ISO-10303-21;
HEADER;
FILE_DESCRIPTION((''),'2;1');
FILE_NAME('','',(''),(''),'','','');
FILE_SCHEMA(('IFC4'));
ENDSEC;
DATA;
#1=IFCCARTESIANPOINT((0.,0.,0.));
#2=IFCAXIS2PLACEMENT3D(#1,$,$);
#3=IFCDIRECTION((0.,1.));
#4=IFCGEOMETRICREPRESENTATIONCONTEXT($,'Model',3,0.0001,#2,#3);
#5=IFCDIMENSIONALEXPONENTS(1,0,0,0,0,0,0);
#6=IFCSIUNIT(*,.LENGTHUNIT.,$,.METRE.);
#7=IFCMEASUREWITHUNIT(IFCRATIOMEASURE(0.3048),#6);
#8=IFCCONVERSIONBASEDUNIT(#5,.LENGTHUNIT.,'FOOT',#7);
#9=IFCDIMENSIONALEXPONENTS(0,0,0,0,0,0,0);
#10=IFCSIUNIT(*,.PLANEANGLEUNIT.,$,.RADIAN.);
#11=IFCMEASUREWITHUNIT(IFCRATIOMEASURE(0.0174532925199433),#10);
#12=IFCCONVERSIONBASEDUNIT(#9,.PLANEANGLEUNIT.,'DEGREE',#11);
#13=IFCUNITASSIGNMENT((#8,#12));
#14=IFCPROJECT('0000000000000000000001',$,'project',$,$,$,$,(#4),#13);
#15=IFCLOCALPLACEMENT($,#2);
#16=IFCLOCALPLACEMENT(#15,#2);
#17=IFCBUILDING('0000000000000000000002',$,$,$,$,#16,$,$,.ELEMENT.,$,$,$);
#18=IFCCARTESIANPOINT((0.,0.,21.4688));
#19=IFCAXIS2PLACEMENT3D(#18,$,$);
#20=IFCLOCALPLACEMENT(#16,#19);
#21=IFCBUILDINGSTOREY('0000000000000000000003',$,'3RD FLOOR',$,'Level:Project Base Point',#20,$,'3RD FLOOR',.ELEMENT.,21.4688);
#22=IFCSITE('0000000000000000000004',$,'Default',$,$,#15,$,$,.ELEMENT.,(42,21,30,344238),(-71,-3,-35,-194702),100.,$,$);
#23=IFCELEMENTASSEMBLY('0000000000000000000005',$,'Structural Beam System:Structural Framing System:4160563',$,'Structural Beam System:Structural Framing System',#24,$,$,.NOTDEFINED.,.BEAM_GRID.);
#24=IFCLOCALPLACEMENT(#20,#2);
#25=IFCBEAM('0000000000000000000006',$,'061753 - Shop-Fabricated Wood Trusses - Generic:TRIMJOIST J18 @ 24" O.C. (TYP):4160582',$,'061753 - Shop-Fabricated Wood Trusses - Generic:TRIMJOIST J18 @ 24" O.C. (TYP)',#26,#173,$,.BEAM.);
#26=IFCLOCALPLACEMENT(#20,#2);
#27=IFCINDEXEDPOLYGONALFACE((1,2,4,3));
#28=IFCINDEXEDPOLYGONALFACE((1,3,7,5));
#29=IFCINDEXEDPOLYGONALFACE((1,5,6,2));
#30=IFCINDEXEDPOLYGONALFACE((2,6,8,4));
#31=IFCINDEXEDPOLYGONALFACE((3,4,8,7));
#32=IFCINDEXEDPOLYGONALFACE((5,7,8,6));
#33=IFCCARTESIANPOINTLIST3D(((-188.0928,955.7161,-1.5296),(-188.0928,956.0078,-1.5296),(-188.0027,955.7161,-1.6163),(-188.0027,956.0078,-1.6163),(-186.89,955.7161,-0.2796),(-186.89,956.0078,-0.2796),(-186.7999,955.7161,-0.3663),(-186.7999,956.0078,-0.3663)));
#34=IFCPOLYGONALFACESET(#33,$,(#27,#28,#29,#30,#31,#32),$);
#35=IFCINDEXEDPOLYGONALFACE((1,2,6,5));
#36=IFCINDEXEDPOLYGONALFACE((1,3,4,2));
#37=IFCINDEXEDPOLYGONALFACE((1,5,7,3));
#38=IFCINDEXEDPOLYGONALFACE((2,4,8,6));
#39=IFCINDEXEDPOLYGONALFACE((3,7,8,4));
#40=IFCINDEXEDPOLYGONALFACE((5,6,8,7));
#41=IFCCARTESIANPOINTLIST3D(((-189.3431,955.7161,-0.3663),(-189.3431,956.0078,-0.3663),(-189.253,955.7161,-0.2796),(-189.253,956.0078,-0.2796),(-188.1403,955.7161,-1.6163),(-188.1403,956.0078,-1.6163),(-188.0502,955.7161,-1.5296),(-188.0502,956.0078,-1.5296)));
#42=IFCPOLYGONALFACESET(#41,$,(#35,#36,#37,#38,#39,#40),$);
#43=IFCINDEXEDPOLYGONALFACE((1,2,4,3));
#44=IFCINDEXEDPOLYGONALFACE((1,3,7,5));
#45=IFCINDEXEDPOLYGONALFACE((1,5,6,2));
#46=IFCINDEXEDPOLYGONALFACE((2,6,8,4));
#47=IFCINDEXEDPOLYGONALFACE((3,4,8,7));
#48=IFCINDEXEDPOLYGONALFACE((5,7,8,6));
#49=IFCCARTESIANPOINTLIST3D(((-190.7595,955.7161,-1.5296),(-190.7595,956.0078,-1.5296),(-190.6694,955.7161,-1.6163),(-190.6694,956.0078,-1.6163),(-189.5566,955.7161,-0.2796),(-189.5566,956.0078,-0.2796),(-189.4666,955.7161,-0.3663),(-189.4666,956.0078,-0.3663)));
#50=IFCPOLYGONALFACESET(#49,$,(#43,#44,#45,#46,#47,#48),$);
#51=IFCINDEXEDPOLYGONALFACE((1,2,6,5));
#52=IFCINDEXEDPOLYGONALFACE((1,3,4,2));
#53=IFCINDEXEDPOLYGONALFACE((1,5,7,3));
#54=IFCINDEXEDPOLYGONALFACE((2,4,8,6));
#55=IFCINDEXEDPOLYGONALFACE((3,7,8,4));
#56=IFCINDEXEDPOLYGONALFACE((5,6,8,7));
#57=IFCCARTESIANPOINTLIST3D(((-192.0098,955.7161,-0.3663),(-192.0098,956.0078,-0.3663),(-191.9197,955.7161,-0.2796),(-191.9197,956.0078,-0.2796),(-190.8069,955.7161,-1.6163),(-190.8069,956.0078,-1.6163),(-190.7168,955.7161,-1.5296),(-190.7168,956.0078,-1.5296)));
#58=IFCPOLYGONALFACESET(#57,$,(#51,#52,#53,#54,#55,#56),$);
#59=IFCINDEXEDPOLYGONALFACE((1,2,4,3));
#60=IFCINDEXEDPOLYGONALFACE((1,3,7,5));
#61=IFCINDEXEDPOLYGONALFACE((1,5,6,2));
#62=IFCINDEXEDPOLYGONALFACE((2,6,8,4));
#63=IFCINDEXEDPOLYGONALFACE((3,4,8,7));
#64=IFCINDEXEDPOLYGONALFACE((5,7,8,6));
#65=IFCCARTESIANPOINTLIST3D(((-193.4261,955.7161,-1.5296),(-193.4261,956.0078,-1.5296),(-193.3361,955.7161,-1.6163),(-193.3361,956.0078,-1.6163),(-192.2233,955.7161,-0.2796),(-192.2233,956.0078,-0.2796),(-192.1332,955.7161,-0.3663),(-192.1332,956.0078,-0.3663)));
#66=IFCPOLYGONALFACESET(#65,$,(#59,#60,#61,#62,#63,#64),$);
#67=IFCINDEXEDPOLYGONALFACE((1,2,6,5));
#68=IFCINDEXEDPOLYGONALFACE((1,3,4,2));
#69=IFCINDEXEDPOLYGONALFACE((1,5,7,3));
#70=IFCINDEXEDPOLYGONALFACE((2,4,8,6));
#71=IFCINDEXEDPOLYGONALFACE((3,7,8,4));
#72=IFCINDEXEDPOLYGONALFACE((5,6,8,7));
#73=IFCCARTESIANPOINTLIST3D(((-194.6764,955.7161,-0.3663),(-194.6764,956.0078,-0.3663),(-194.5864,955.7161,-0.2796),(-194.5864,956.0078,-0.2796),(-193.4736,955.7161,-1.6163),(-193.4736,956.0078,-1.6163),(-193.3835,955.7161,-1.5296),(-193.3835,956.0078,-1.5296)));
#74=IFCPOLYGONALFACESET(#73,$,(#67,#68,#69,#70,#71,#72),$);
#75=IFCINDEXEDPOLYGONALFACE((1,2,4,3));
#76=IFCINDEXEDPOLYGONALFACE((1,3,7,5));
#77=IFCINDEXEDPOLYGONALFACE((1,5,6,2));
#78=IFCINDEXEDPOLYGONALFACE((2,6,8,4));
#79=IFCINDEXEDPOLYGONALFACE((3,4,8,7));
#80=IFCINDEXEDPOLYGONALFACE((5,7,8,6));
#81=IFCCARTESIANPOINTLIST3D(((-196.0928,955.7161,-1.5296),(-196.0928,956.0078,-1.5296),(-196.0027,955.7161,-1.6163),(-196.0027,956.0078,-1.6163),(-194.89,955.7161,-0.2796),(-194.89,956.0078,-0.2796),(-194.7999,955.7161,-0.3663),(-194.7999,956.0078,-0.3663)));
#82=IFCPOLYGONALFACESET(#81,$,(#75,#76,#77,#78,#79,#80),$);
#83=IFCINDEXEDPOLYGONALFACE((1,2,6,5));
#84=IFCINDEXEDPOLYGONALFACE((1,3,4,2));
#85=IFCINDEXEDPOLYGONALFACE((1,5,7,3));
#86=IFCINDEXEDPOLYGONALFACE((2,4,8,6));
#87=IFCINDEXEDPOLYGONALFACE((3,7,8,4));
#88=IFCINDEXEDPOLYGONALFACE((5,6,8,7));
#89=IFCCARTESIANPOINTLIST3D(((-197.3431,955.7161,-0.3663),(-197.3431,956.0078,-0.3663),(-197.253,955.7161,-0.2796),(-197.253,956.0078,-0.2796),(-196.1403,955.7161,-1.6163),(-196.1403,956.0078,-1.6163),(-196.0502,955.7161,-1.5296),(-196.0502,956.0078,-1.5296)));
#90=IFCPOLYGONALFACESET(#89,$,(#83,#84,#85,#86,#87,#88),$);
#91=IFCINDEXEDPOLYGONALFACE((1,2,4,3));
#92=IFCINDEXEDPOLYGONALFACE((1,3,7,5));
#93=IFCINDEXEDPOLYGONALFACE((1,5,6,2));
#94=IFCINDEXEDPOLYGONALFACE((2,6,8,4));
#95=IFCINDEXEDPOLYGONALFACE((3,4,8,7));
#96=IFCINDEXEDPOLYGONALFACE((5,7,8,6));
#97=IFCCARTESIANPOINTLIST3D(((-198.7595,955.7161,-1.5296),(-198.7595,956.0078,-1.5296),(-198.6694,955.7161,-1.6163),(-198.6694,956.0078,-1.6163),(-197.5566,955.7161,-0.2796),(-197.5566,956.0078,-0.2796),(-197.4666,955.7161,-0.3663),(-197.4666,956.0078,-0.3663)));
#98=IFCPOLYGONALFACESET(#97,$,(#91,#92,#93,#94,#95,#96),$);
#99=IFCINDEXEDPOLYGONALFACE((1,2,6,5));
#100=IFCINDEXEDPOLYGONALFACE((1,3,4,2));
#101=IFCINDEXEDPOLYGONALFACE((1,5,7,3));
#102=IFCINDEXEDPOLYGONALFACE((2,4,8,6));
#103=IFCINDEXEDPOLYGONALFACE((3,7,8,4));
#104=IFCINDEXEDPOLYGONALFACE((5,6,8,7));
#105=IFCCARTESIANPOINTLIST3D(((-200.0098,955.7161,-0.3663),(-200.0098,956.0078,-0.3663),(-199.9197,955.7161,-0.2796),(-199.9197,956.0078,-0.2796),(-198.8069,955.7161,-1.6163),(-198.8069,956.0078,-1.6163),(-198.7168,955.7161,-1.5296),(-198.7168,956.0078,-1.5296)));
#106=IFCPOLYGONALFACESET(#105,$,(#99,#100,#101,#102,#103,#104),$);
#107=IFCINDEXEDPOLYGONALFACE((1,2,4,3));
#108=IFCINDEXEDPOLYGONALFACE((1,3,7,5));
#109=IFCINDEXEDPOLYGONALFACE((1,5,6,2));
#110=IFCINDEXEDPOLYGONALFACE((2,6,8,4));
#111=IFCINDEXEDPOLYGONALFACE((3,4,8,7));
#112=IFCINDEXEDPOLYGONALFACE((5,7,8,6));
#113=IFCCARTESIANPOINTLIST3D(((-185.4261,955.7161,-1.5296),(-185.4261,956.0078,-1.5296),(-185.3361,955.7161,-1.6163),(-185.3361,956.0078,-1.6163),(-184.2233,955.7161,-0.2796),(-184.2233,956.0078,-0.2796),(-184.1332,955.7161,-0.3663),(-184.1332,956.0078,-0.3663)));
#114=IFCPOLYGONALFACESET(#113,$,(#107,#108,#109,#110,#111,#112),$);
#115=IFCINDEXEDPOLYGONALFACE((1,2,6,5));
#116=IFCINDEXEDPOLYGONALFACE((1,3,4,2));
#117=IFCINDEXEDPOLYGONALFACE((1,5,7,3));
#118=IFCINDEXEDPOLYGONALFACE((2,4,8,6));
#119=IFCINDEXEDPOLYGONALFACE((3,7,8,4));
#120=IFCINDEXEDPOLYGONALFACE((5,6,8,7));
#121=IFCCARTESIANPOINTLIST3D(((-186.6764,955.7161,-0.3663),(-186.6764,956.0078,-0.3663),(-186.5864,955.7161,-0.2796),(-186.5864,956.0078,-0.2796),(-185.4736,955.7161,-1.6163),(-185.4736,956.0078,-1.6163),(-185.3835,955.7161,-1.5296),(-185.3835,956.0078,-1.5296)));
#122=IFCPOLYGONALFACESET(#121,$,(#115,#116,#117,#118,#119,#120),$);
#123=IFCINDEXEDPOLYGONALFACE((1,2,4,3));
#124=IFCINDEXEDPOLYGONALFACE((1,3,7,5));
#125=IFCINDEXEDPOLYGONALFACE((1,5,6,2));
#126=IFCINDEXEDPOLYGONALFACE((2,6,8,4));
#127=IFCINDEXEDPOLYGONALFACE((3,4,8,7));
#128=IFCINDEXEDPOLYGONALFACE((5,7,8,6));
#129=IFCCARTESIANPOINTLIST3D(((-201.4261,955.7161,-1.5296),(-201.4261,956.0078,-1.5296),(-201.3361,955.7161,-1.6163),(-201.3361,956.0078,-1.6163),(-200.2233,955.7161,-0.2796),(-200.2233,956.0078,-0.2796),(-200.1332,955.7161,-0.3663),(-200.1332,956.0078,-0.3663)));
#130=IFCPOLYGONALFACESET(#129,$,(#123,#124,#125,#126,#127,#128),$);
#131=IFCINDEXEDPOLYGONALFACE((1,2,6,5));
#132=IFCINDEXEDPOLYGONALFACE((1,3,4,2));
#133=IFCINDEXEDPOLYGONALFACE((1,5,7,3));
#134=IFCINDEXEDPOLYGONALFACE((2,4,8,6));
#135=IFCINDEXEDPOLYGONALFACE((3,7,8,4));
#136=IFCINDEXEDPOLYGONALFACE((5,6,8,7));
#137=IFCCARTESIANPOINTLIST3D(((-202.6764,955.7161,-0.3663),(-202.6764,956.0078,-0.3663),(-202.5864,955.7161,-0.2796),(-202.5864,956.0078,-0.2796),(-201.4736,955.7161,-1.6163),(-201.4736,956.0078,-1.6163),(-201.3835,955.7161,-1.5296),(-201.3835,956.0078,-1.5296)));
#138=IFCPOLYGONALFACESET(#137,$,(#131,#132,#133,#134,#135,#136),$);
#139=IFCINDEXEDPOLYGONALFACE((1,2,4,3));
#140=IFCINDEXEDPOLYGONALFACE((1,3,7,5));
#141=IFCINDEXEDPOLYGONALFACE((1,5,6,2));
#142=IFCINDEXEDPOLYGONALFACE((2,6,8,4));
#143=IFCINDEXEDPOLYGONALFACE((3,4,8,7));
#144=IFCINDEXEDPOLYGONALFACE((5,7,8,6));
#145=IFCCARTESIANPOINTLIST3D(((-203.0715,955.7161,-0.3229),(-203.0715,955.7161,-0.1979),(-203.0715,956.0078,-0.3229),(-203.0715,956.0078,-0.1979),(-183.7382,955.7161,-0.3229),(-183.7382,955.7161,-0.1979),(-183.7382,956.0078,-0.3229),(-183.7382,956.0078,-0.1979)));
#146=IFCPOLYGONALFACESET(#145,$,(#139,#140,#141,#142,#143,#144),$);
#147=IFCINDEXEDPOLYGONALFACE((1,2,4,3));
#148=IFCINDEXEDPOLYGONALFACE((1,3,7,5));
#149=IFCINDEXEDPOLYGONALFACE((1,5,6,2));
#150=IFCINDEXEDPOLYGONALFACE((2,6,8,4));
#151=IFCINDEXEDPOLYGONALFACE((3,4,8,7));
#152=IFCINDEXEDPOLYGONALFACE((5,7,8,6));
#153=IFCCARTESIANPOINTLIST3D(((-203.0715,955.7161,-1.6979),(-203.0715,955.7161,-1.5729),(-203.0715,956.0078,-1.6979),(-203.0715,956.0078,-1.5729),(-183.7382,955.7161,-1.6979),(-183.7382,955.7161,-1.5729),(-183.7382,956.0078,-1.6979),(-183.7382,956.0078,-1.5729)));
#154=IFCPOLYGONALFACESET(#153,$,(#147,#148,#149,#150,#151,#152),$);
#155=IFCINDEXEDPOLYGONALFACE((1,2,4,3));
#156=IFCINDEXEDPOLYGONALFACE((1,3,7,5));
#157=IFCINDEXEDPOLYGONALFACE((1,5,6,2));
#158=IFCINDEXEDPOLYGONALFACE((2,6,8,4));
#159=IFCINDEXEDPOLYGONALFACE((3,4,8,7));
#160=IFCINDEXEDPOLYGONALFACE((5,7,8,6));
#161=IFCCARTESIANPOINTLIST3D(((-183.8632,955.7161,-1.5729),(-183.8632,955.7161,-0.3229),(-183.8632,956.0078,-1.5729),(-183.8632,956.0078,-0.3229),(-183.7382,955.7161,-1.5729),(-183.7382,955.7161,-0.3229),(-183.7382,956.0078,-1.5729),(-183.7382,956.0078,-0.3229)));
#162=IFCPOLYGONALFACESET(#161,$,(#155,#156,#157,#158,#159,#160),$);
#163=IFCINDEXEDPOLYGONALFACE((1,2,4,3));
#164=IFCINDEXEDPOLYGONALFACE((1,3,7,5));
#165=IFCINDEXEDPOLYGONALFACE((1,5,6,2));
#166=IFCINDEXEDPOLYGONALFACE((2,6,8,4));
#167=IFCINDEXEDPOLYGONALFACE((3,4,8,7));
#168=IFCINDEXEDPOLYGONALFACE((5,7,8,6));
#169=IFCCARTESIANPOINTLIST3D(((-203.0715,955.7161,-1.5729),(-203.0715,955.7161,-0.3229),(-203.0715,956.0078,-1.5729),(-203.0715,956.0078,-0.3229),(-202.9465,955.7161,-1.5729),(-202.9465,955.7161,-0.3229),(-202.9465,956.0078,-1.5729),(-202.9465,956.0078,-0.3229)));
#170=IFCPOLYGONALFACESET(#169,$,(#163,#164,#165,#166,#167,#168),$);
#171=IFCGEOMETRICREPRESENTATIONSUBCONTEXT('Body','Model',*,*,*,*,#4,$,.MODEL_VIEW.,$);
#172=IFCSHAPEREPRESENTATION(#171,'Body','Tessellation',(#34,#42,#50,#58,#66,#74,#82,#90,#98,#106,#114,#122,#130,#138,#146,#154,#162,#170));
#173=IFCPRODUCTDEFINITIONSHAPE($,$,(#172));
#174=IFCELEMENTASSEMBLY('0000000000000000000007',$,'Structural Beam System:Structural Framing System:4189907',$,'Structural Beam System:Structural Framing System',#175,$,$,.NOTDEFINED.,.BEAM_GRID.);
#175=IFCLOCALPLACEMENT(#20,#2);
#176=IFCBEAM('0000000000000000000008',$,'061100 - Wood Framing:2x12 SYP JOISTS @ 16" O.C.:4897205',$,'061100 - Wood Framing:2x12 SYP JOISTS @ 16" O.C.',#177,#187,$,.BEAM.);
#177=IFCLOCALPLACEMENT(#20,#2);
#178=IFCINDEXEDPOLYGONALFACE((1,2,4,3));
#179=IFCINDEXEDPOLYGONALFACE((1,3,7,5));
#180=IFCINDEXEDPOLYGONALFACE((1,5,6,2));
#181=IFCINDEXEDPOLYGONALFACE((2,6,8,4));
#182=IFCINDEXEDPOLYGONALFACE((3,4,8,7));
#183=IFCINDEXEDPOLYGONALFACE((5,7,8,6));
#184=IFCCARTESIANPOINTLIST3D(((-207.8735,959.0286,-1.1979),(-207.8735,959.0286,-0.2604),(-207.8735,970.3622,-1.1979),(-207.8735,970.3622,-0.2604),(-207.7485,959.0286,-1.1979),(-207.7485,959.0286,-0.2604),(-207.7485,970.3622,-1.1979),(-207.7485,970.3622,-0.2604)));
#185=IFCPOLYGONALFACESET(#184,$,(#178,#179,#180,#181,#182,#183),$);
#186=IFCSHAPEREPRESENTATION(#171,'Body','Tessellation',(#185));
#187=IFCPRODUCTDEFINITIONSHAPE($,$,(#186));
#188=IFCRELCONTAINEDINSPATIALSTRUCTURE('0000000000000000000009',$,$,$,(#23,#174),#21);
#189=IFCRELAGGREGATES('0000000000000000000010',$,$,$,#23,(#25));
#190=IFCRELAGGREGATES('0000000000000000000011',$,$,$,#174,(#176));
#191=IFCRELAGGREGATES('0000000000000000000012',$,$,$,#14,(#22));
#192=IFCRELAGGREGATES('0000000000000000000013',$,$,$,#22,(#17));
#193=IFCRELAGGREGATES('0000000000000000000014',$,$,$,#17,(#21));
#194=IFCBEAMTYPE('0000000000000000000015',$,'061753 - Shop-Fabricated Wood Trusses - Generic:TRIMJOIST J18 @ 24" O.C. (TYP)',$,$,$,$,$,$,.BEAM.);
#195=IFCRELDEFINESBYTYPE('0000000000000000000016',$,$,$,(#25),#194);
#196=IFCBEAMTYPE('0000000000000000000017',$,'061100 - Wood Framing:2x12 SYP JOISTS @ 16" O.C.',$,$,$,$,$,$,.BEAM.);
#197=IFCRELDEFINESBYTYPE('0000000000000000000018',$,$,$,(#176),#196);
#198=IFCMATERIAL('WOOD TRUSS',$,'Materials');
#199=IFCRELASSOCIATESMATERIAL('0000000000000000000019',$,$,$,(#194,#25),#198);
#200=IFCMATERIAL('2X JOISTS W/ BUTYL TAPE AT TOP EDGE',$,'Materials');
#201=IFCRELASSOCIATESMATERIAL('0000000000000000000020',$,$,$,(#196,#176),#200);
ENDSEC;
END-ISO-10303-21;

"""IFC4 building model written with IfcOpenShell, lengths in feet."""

from ifc_helpers import new_model, entity, si_unit, converted_unit, direction, frame, frame_2d, origin, origin_2d_with_axis, place, context, subcontext, project, spatial, rectangle, extrude, source, transform, mapped, material, material_profile, profile_set, profile_usage, type_object, type_shapes, element, aggregate, save


model = new_model("IFC4")

# Units and contexts
model_context = context("Model", 3, precision=0.0001, world=origin(), true_north=direction((0.0, 1.0)))
body_context = subcontext(model_context, "Body", "Model", "MODEL_VIEW")
ifc_project = project(units=[converted_unit("LENGTHUNIT", "FOOT", entity("IfcRatioMeasure", 0.3048), si_unit("LENGTHUNIT", "METRE"), dimensions=[1, 0, 0, 0, 0, 0, 0]), converted_unit("PLANEANGLEUNIT", "DEGREE", entity("IfcRatioMeasure", 0.0174532925199433), si_unit("PLANEANGLEUNIT", "RADIAN"), dimensions=[0, 0, 0, 0, 0, 0, 0])], contexts=[model_context])

# Site, building, storey
site_placement = place(None, origin())
site = spatial("IfcSite", under=ifc_project, at=site_placement, Name="Default", CompositionType="ELEMENT", RefLatitude=(42, 21, 30, 344238), RefLongitude=(-71, -3, -35, -194702), RefElevation=100.0)
building_placement = place(site_placement, origin())
building = spatial("IfcBuilding", under=site, at=building_placement, CompositionType="ELEMENT")
storey_placement = place(building_placement, frame((0.0, 0.0, 21.4688)))
storey = spatial("IfcBuildingStorey", under=building, at=storey_placement, Name="3RD FLOOR", ObjectType="Level:Project Base Point", LongName="3RD FLOOR", CompositionType="ELEMENT", Elevation=21.4688)

# Shared definitions
ifc_material_1 = material(Name="WOOD TRUSS", Category="Materials")
ifc_material_profile_1 = material_profile(ifc_material_1, rectangle(XDim=1.7347, YDim=0.125, at=frame_2d((0.0, 0.0), x_axis=(1.0, 0.0))), Name="TRIMJOIST J18 @ 24\" O.C. (TYP)")
ifc_material_profile_2 = material_profile(ifc_material_1, rectangle(XDim=1.7347, YDim=0.125, at=frame_2d((0.0, 0.0), x_axis=(1.0, 0.0))), Name="TRIMJOIST J18 @ 24\" O.C. (TYP)")
ifc_material_profile_3 = material_profile(ifc_material_1, rectangle(XDim=1.7347, YDim=0.125, at=frame_2d((0.0, 0.0), x_axis=(1.0, 0.0))), Name="TRIMJOIST J18 @ 24\" O.C. (TYP)")
ifc_material_profile_4 = material_profile(ifc_material_1, rectangle(XDim=1.7347, YDim=0.125, at=frame_2d((0.0, 0.0), x_axis=(1.0, 0.0))), Name="TRIMJOIST J18 @ 24\" O.C. (TYP)")
ifc_material_profile_5 = material_profile(ifc_material_1, rectangle(XDim=1.7347, YDim=0.125, at=frame_2d((0.0, 0.0), x_axis=(1.0, 0.0))), Name="TRIMJOIST J18 @ 24\" O.C. (TYP)")
ifc_material_profile_6 = material_profile(ifc_material_1, rectangle(XDim=1.7347, YDim=0.125, at=frame_2d((0.0, 0.0), x_axis=(1.0, 0.0))), Name="TRIMJOIST J18 @ 24\" O.C. (TYP)")
ifc_material_profile_7 = material_profile(ifc_material_1, rectangle(XDim=1.7347, YDim=0.125, at=frame_2d((0.0, 0.0), x_axis=(1.0, 0.0))), Name="TRIMJOIST J18 @ 24\" O.C. (TYP)")
ifc_material_profile_8 = material_profile(ifc_material_1, rectangle(XDim=1.7347, YDim=0.125, at=frame_2d((0.0, 0.0), x_axis=(1.0, 0.0))), Name="TRIMJOIST J18 @ 24\" O.C. (TYP)")
ifc_material_profile_9 = material_profile(ifc_material_1, rectangle(XDim=1.7347, YDim=0.125, at=frame_2d((0.0, 0.0), x_axis=(1.0, 0.0))), Name="TRIMJOIST J18 @ 24\" O.C. (TYP)")
ifc_material_profile_10 = material_profile(ifc_material_1, rectangle(XDim=1.7347, YDim=0.125, at=origin_2d_with_axis()), Name="TRIMJOIST J18 @ 24\" O.C. (TYP)")
ifc_material_profile_11 = material_profile(ifc_material_1, rectangle(XDim=0.125, YDim=0.2917, at=origin_2d_with_axis()), Name="TRIMJOIST J18 @ 24\" O.C. (TYP)")
ifc_material_profile_12 = material_profile(ifc_material_1, rectangle(XDim=0.125, YDim=0.2917, at=origin_2d_with_axis()), Name="TRIMJOIST J18 @ 24\" O.C. (TYP)")
ifc_material_profile_13 = material_profile(ifc_material_1, rectangle(XDim=1.25, YDim=0.2917, at=origin_2d_with_axis()), Name="TRIMJOIST J18 @ 24\" O.C. (TYP)")
ifc_material_profile_14 = material_profile(ifc_material_1, rectangle(XDim=1.25, YDim=0.2917, at=origin_2d_with_axis()), Name="TRIMJOIST J18 @ 24\" O.C. (TYP)")
ifc_profile_set_1 = profile_set([ifc_material_profile_1, ifc_material_profile_2, ifc_material_profile_3, ifc_material_profile_4, ifc_material_profile_5, ifc_material_profile_6, ifc_material_profile_7, ifc_material_profile_8, ifc_material_profile_9, ifc_material_profile_10, ifc_material_profile_11, ifc_material_profile_12, ifc_material_profile_13, ifc_material_profile_14], Name="TRIMJOIST J18 @ 24\" O.C. (TYP)")

# Element assembly
assembly_1_placement = place(storey_placement, origin())
assembly_1 = element("IfcElementAssembly", 1, at=assembly_1_placement, inside=storey, Name="Structural Beam System:Structural Framing System:4160563", ObjectType="Structural Beam System:Structural Framing System", AssemblyPlace="NOTDEFINED", PredefinedType="BEAM_GRID")

# Beam
ifc_profile_usage_1 = profile_usage(ifc_profile_set_1, cardinal=8)
beam_type_1 = type_object("IfcBeamType", Name="061753 - Shop-Fabricated Wood Trusses - Generic:TRIMJOIST J18 @ 24\" O.C. (TYP)", PredefinedType="BEAM", material=ifc_profile_set_1)
shared_shape_1 = source(origin(), body_context, "Body", "SweptSolid", [
    extrude(rectangle(XDim=1.7347, YDim=0.125, at=frame_2d((0.0, 0.0), x_axis=(1.0, 0.0))), frame((5.9585, -0.1458, 0.0), z_axis=(0.0, 1.0, 0.0), x_axis=(0.693383, 0.0, 0.720569)), (0.0, 0.0, 1.0), 0.2917),
    extrude(rectangle(XDim=1.7347, YDim=0.125, at=origin_2d_with_axis()), frame((4.7082, -0.1458, 0.0), z_axis=(0.0, 1.0, 0.0), x_axis=(0.693383, 0.0, -0.720569)), (0.0, 0.0, 1.0), 0.2917),
    extrude(rectangle(XDim=1.7347, YDim=0.125, at=frame_2d((0.0, 0.0), x_axis=(1.0, 0.0))), frame((3.2918, -0.1458, 0.0), z_axis=(0.0, 1.0, 0.0), x_axis=(0.693383, 0.0, 0.720569)), (0.0, 0.0, 1.0), 0.2917),
    extrude(rectangle(XDim=1.7347, YDim=0.125, at=frame_2d((0.0, 0.0), x_axis=(1.0, 0.0))), frame((2.0415, -0.1458, 0.0), z_axis=(0.0, 1.0, 0.0), x_axis=(0.693383, 0.0, -0.720569)), (0.0, 0.0, 1.0), 0.2917),
    extrude(rectangle(XDim=1.7347, YDim=0.125, at=frame_2d((0.0, 0.0), x_axis=(1.0, 0.0))), frame((0.6251, -0.1458, 0.0), z_axis=(0.0, 1.0, 0.0), x_axis=(0.693383, 0.0, 0.720569)), (0.0, 0.0, 1.0), 0.2917),
    extrude(rectangle(XDim=1.7347, YDim=0.125, at=frame_2d((0.0, 0.0), x_axis=(1.0, 0.0))), frame((-0.6251, -0.1458, 0.0), z_axis=(0.0, 1.0, 0.0), x_axis=(0.693383, 0.0, -0.720569)), (0.0, 0.0, 1.0), 0.2917),
    extrude(rectangle(XDim=1.7347, YDim=0.125, at=frame_2d((0.0, 0.0), x_axis=(1.0, 0.0))), frame((-2.0415, -0.1458, 0.0), z_axis=(0.0, 1.0, 0.0), x_axis=(0.693383, 0.0, 0.720569)), (0.0, 0.0, 1.0), 0.2917),
    extrude(rectangle(XDim=1.7347, YDim=0.125, at=origin_2d_with_axis()), frame((-3.2918, -0.1458, 0.0), z_axis=(0.0, 1.0, 0.0), x_axis=(0.693383, 0.0, -0.720569)), (0.0, 0.0, 1.0), 0.2917),
    extrude(rectangle(XDim=1.7347, YDim=0.125, at=frame_2d((0.0, 0.0), x_axis=(1.0, 0.0))), frame((-4.7082, -0.1458, 0.0), z_axis=(0.0, 1.0, 0.0), x_axis=(0.693383, 0.0, 0.720569)), (0.0, 0.0, 1.0), 0.2917),
    extrude(rectangle(XDim=1.7347, YDim=0.125, at=frame_2d((0.0, 0.0), x_axis=(1.0, 0.0))), frame((-5.9585, -0.1458, 0.0), z_axis=(0.0, 1.0, 0.0), x_axis=(0.693383, 0.0, -0.720569)), (0.0, 0.0, 1.0), 0.2917),
    extrude(rectangle(XDim=1.7347, YDim=0.125, at=frame_2d((0.0, 0.0), x_axis=(1.0, 0.0))), frame((8.6251, -0.1458, 0.0), z_axis=(0.0, 1.0, 0.0), x_axis=(0.693383, 0.0, 0.720569)), (0.0, 0.0, 1.0), 0.2917),
    extrude(rectangle(XDim=1.7347, YDim=0.125, at=origin_2d_with_axis()), frame((7.3749, -0.1458, 0.0), z_axis=(0.0, 1.0, 0.0), x_axis=(0.693383, 0.0, -0.720569)), (0.0, 0.0, 1.0), 0.2917),
    extrude(rectangle(XDim=1.7347, YDim=0.125, at=frame_2d((0.0, 0.0), x_axis=(1.0, 0.0))), frame((-7.3749, -0.1458, 0.0), z_axis=(0.0, 1.0, 0.0), x_axis=(0.693383, 0.0, 0.720569)), (0.0, 0.0, 1.0), 0.2917),
    extrude(rectangle(XDim=1.7347, YDim=0.125, at=origin_2d_with_axis()), frame((-8.6251, -0.1458, 0.0), z_axis=(0.0, 1.0, 0.0), x_axis=(0.693383, 0.0, -0.720569)), (0.0, 0.0, 1.0), 0.2917),
    extrude(rectangle(XDim=0.125, YDim=0.2917, at=origin_2d_with_axis()), frame((-9.6667, 0.0, 0.6875), z_axis=(1.0, 0.0, 0.0), x_axis=(0.0, 0.0, -1.0)), (0.0, 0.0, 1.0), 19.3333),
    extrude(rectangle(XDim=0.125, YDim=0.2917, at=origin_2d_with_axis()), frame((-9.6667, 0.0, -0.6875), z_axis=(1.0, 0.0, 0.0), x_axis=(0.0, 0.0, -1.0)), (0.0, 0.0, 1.0), 19.3333),
    extrude(rectangle(XDim=1.25, YDim=0.2917, at=origin_2d_with_axis()), frame((9.5417, 0.0, 0.0), z_axis=(1.0, 0.0, 0.0), x_axis=(0.0, 0.0, -1.0)), (0.0, 0.0, 1.0), 0.125),
    extrude(rectangle(XDim=1.25, YDim=0.2917, at=origin_2d_with_axis()), frame((-9.6667, 0.0, 0.0), z_axis=(1.0, 0.0, 0.0), x_axis=(0.0, 0.0, -1.0)), (0.0, 0.0, 1.0), 0.125),
])
type_shapes(beam_type_1, [shared_shape_1])
beam_1_placement = place(assembly_1_placement, frame((-193.4048, 955.8619, -0.9479)))
beam_1 = element("IfcBeam", 2, at=beam_1_placement, type_object=beam_type_1, material=ifc_profile_usage_1, Name="061753 - Shop-Fabricated Wood Trusses - Generic:TRIMJOIST J18 @ 24\" O.C. (TYP):4160582", ObjectType="061753 - Shop-Fabricated Wood Trusses - Generic:TRIMJOIST J18 @ 24\" O.C. (TYP)", PredefinedType="BEAM", context=body_context, shape_type="MappedRepresentation", body=[
    mapped(shared_shape_1, transform((0.0, 0.0, 0.0), scale=1.0)),
])
aggregate(assembly_1, [beam_1])

# Element assembly, beam
assembly_2_placement = place(storey_placement, origin())
assembly_2 = element("IfcElementAssembly", 3, at=assembly_2_placement, inside=storey, Name="Structural Beam System:Structural Framing System:4189907", ObjectType="Structural Beam System:Structural Framing System", AssemblyPlace="NOTDEFINED", PredefinedType="BEAM_GRID")
ifc_material_2 = material(Name="2X JOISTS W/ BUTYL TAPE AT TOP EDGE", Category="Materials")
ifc_material_profile_15 = material_profile(ifc_material_2, rectangle(XDim=0.9375, YDim=0.125, at=origin_2d_with_axis()), Name="2x12 SYP JOISTS @ 16\" O.C.")
ifc_profile_set_2 = profile_set([ifc_material_profile_15], Name="2x12 SYP JOISTS @ 16\" O.C.")
ifc_profile_usage_2 = profile_usage(ifc_profile_set_2, cardinal=8)
beam_type_2 = type_object("IfcBeamType", Name="061100 - Wood Framing:2x12 SYP JOISTS @ 16\" O.C.", PredefinedType="BEAM", material=ifc_profile_set_2)
shared_shape_2 = source(origin(), body_context, "Body", "SweptSolid", [
    extrude(rectangle(XDim=0.9375, YDim=0.125, at=origin_2d_with_axis()), frame((-5.6668, 0.0, 0.0), z_axis=(1.0, 0.0, 0.0), x_axis=(0.0, 0.0, -1.0)), (0.0, 0.0, 1.0), 11.3336),
])
type_shapes(beam_type_2, [shared_shape_2])
beam_2_placement = place(assembly_2_placement, frame((-207.811, 964.6954, -0.7292), z_axis=(0.0, 0.0, 1.0), x_axis=(0.0, 1.0, 0.0)))
beam_2 = element("IfcBeam", 4, at=beam_2_placement, type_object=beam_type_2, material=ifc_profile_usage_2, Name="061100 - Wood Framing:2x12 SYP JOISTS @ 16\" O.C.:4897205", ObjectType="061100 - Wood Framing:2x12 SYP JOISTS @ 16\" O.C.", PredefinedType="BEAM", context=body_context, shape_type="MappedRepresentation", body=[
    mapped(shared_shape_2, transform((0.0, 0.0, 0.0), scale=1.0)),
])
aggregate(assembly_2, [beam_2])

save(model, "model.ifc")
